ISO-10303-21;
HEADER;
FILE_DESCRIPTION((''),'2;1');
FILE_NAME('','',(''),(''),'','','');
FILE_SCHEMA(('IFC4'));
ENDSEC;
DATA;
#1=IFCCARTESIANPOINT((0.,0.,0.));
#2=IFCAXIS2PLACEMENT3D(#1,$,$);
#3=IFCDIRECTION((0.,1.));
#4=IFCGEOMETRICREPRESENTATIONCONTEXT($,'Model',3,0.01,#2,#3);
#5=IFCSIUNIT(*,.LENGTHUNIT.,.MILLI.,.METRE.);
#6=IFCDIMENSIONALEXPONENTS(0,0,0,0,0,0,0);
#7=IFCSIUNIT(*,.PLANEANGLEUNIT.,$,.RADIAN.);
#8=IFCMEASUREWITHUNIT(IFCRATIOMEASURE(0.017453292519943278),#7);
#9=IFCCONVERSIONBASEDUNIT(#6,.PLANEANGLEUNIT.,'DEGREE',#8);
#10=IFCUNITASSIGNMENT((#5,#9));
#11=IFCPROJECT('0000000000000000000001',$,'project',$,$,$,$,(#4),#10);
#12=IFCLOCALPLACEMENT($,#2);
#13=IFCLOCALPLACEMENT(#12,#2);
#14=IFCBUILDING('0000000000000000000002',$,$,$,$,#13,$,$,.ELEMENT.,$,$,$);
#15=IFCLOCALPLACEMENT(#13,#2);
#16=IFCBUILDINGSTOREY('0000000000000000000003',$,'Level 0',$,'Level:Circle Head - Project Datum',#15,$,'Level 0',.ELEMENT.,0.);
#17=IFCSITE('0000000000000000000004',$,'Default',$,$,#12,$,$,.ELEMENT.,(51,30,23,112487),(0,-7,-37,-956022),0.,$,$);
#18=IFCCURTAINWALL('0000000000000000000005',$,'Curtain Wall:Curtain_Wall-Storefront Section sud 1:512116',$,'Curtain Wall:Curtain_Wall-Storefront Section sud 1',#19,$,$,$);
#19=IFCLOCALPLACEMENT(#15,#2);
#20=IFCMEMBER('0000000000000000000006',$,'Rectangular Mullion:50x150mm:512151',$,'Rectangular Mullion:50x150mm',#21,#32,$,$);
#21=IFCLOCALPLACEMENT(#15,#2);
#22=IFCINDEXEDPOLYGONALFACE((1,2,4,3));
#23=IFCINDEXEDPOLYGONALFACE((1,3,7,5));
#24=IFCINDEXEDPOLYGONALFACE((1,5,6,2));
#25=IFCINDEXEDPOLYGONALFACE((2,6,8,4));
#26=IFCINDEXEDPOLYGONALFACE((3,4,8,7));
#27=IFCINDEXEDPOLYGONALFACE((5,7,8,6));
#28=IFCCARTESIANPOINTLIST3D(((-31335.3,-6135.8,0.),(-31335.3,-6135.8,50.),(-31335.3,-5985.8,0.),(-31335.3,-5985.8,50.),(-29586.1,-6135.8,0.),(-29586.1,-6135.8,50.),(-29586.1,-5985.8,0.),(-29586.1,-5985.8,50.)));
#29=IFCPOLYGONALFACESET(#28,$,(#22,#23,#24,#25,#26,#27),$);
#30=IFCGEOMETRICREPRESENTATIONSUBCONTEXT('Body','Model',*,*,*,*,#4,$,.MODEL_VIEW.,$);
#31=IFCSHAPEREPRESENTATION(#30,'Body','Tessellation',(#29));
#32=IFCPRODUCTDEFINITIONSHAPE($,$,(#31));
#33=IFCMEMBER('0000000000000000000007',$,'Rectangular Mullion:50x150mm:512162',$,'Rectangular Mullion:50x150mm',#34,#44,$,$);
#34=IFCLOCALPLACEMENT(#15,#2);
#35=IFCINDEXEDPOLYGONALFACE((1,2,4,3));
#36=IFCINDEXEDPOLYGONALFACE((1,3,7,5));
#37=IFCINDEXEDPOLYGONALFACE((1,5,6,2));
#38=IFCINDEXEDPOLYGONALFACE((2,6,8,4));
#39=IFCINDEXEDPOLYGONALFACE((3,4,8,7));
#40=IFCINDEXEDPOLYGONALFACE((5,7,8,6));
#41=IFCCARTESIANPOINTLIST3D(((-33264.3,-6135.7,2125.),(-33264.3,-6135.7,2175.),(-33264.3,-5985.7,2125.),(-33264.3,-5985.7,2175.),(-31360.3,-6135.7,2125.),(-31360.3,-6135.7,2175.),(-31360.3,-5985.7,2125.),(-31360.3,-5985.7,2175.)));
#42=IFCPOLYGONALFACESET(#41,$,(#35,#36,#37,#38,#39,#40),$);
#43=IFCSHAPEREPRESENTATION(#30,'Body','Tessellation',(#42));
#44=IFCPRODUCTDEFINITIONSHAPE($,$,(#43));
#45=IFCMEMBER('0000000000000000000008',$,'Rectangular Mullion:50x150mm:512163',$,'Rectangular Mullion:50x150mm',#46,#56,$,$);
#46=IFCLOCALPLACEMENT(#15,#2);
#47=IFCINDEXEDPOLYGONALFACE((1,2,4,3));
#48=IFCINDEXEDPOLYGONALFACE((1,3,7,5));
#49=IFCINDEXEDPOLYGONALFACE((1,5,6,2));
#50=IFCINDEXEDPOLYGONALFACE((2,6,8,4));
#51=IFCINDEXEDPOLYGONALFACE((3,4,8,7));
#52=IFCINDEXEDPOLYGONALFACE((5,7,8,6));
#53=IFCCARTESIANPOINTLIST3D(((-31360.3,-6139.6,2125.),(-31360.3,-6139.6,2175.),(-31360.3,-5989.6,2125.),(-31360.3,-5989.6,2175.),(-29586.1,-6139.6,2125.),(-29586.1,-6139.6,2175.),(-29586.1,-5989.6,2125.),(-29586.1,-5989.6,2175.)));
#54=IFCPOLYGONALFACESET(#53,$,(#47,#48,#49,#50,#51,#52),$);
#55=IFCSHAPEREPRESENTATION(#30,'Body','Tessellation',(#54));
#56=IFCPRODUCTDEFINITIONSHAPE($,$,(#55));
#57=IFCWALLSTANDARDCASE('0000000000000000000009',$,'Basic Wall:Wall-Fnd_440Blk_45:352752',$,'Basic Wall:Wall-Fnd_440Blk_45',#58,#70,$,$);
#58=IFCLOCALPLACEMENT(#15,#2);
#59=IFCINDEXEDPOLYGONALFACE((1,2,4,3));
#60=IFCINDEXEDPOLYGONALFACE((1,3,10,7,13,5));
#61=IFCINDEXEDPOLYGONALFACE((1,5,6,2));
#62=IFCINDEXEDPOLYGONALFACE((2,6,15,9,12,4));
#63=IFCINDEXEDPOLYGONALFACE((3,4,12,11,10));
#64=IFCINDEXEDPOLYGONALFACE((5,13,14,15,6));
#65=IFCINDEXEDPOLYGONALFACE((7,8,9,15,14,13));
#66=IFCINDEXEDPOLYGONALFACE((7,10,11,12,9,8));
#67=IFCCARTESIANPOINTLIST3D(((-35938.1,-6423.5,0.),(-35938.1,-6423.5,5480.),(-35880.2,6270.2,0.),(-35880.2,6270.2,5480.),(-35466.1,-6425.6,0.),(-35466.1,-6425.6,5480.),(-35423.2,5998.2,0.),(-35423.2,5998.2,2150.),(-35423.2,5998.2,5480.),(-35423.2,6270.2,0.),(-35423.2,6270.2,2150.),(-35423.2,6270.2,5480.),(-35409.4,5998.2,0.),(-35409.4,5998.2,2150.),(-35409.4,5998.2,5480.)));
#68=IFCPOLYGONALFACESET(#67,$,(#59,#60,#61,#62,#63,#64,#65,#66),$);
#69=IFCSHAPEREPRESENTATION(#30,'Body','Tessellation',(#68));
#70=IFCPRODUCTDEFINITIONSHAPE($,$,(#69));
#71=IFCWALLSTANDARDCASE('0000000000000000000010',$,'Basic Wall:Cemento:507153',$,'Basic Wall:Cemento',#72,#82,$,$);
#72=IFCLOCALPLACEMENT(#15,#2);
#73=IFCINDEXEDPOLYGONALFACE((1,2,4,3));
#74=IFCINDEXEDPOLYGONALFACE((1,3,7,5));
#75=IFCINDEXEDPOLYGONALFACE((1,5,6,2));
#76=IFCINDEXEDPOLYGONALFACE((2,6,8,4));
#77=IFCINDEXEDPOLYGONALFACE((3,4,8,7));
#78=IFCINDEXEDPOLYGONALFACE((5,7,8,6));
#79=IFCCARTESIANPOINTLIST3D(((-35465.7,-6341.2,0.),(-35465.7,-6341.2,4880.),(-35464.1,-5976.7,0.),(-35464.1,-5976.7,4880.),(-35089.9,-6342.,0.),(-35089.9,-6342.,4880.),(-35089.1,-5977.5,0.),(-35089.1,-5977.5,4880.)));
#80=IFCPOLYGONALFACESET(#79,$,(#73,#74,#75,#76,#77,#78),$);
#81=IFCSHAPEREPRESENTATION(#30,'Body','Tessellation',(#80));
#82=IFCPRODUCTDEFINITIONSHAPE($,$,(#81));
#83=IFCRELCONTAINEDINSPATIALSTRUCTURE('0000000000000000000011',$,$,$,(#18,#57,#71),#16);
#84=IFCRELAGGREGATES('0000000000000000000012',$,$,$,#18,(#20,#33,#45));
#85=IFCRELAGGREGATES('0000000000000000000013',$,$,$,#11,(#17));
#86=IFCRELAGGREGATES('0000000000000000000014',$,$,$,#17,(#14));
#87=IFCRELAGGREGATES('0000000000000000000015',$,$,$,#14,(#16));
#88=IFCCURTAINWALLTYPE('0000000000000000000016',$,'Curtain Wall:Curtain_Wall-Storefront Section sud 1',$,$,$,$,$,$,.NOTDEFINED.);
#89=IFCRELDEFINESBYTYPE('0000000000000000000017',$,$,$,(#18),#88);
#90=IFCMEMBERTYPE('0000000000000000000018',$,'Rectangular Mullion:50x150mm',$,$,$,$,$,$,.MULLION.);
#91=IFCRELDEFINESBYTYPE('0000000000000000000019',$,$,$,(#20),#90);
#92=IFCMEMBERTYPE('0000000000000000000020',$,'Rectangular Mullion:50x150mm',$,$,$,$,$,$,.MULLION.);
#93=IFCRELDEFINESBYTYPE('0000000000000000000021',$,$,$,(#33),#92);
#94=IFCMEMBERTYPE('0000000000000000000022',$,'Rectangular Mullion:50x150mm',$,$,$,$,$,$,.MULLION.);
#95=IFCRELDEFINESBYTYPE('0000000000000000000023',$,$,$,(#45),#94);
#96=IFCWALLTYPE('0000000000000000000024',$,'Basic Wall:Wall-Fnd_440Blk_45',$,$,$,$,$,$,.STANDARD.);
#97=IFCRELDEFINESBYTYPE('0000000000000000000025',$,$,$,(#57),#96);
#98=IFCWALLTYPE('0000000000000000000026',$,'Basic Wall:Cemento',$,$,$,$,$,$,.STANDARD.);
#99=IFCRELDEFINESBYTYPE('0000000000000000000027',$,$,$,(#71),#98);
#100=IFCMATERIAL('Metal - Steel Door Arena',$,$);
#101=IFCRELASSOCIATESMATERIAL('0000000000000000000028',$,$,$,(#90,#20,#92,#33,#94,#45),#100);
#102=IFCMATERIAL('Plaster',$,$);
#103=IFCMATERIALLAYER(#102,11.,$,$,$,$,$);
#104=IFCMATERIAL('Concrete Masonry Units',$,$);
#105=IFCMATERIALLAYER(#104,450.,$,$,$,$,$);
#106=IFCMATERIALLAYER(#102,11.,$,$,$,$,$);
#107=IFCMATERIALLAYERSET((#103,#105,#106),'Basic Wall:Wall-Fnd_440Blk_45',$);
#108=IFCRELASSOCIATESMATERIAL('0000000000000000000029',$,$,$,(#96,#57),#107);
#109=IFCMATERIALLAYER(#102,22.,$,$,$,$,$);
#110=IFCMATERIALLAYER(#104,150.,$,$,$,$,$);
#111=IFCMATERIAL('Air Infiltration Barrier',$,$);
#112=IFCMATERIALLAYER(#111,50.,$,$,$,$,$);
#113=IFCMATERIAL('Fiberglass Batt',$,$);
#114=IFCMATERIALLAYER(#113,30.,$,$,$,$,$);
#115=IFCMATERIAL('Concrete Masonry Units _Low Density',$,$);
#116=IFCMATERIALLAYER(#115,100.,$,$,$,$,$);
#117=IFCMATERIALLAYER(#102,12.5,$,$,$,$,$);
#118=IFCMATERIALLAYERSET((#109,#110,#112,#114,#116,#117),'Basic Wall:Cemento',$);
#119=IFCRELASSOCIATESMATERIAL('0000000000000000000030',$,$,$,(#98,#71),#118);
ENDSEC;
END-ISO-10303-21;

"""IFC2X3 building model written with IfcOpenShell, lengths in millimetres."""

from ifc_helpers import new_model, entity, si_unit, converted_unit, direction, frame, frame_2d, origin, origin_2d_with_axis, place, context, subcontext, project, spatial, polyline, rectangle, outline, extrude, source, transform, mapped, material, layer, layer_set, layer_usage, type_object, type_shapes, element, aggregate, save


model = new_model("IFC2X3")

# Units and contexts
model_context = context("Model", 3, precision=0.01, world=origin(), true_north=direction((0.0, 1.0)))
body_context = subcontext(model_context, "Body", "Model", "MODEL_VIEW")
ifc_project = project(units=[si_unit("LENGTHUNIT", "METRE", prefix="MILLI"), converted_unit("PLANEANGLEUNIT", "DEGREE", entity("IfcRatioMeasure", 0.017453292519943278), si_unit("PLANEANGLEUNIT", "RADIAN"), dimensions=[0, 0, 0, 0, 0, 0, 0])], contexts=[model_context])

# Site, building, storey
site_placement = place(None, origin())
site = spatial("IfcSite", under=ifc_project, at=site_placement, Name="Default", CompositionType="ELEMENT", RefLatitude=(51, 30, 23, 112487), RefLongitude=(0, -7, -37, -956022), RefElevation=0.0)
building_placement = place(site_placement, origin())
building = spatial("IfcBuilding", under=site, at=building_placement, CompositionType="ELEMENT")
storey_placement = place(building_placement, origin())
storey = spatial("IfcBuildingStorey", under=building, at=storey_placement, Name="Level 0", ObjectType="Level:Circle Head - Project Datum", LongName="Level 0", CompositionType="ELEMENT", Elevation=0.0)

# Curtain wall, members
curtain_wall_type = type_object("IfcCurtainWallType", Name="Curtain Wall:Curtain_Wall-Storefront Section sud 1", PredefinedType="NOTDEFINED")
curtain_wall_placement = place(storey_placement, origin())
curtain_wall = element("IfcCurtainWall", 1, at=curtain_wall_placement, inside=storey, type_object=curtain_wall_type, Name="Curtain Wall:Curtain_Wall-Storefront Section sud 1:512116", ObjectType="Curtain Wall:Curtain_Wall-Storefront Section sud 1")
ifc_material_1 = material(Name="Metal - Steel Door Arena")
member_type_1 = type_object("IfcMemberType", Name="Rectangular Mullion:50x150mm", PredefinedType="MULLION", material=ifc_material_1)
shared_shape_1 = source(origin(), body_context, "Body", "SweptSolid", [
    extrude(rectangle(XDim=150.0, YDim=50.0, at=origin_2d_with_axis()), frame((-25.0, 0.0, -1749.2), z_axis=(0.0, 0.0, 1.0), x_axis=(0.0, -1.0, 0.0)), (0.0, 0.0, 1.0), 1749.2),
])
type_shapes(member_type_1, [shared_shape_1])
member_1_placement = place(curtain_wall_placement, frame((-31335.3, -6060.8, 0.0), z_axis=(-1.0, 0.0, 0.0), x_axis=(0.0, 0.0, -1.0)))
member_1 = element("IfcMember", 2, at=member_1_placement, type_object=member_type_1, material=ifc_material_1, Name="Rectangular Mullion:50x150mm:512151", ObjectType="Rectangular Mullion:50x150mm", context=body_context, shape_type="MappedRepresentation", body=[
    mapped(shared_shape_1, transform((0.0, 0.0, 0.0), scale=1.0)),
])
member_type_2 = type_object("IfcMemberType", Name="Rectangular Mullion:50x150mm", PredefinedType="MULLION", material=ifc_material_1)
shared_shape_2 = source(origin(), body_context, "Body", "SweptSolid", [
    extrude(rectangle(XDim=150.0, YDim=50.0, at=origin_2d_with_axis()), frame((0.0, 0.0, -1904.0), z_axis=(0.0, 0.0, 1.0), x_axis=(0.0, -1.0, 0.0)), (0.0, 0.0, 1.0), 1904.0),
])
type_shapes(member_type_2, [shared_shape_2])
member_2_placement = place(curtain_wall_placement, frame((-31360.3, -6060.7, 2150.0), z_axis=(1.0, 0.0, 0.0), x_axis=(0.0, 0.0, 1.0)))
member_2 = element("IfcMember", 3, at=member_2_placement, type_object=member_type_2, material=ifc_material_1, Name="Rectangular Mullion:50x150mm:512162", ObjectType="Rectangular Mullion:50x150mm", context=body_context, shape_type="MappedRepresentation", body=[
    mapped(shared_shape_2, transform((0.0, 0.0, 0.0), scale=1.0)),
])
member_type_3 = type_object("IfcMemberType", Name="Rectangular Mullion:50x150mm", PredefinedType="MULLION", material=ifc_material_1)
shared_shape_3 = source(origin(), body_context, "Body", "SweptSolid", [
    extrude(rectangle(XDim=150.0, YDim=50.0, at=origin_2d_with_axis()), frame((0.0, 0.0, -1774.2), z_axis=(0.0, 0.0, 1.0), x_axis=(0.0, -1.0, 0.0)), (0.0, 0.0, 1.0), 1774.2),
])
type_shapes(member_type_3, [shared_shape_3])
member_3_placement = place(curtain_wall_placement, frame((-29586.1, -6064.6, 2150.0), z_axis=(1.0, 0.0, 0.0), x_axis=(0.0, 0.0, 1.0)))
member_3 = element("IfcMember", 4, at=member_3_placement, type_object=member_type_3, material=ifc_material_1, Name="Rectangular Mullion:50x150mm:512163", ObjectType="Rectangular Mullion:50x150mm", context=body_context, shape_type="MappedRepresentation", body=[
    mapped(shared_shape_3, transform((0.0, 0.0, 0.0), scale=1.0)),
])
aggregate(curtain_wall, [member_1, member_2, member_3])

# Wall, opening
ifc_material_2 = material(Name="Plaster")
ifc_layer_1 = layer(ifc_material_2, 11.0)
ifc_material_3 = material(Name="Concrete Masonry Units")
ifc_layer_2 = layer(ifc_material_3, 450.0)
ifc_layer_3 = layer(ifc_material_2, 11.0)
ifc_layer_set_1 = layer_set([ifc_layer_1, ifc_layer_2, ifc_layer_3], Name="Basic Wall:Wall-Fnd_440Blk_45")
ifc_layer_usage_1 = layer_usage(ifc_layer_set_1, "AXIS2", "NEGATIVE", 236.0)
wall_type_1 = type_object("IfcWallType", Name="Basic Wall:Wall-Fnd_440Blk_45", PredefinedType="STANDARD", material=ifc_layer_set_1)
wall_1_placement = place(storey_placement, frame((-35644.2, 6271.3, 0.0), z_axis=(0.0, 0.0, 1.0), x_axis=(-0.004561, -0.99999, 0.0)))
wall_1 = element("IfcWallStandardCase", 5, at=wall_1_placement, inside=storey, type_object=wall_type_1, material=ifc_layer_usage_1, Name="Basic Wall:Wall-Fnd_440Blk_45:352752", ObjectType="Basic Wall:Wall-Fnd_440Blk_45", context=body_context, shape_type="SweptSolid", body=[
    extrude(outline(polyline([(12696.0, -236.0), (12696.0, 236.0), (12611.6, 236.0), (12247.1, 236.0), (272.0, 236.0), (272.1, 222.2), (0.1, 221.0), (2.2, -236.0), (12696.0, -236.0)])), origin(), (0.0, 0.0, 1.0), 5480.0),
])
opening_placement = place(wall_1_placement, origin())
element("IfcOpeningElement", 6, at=opening_placement, cuts=wall_1, ObjectType="Opening", context=body_context, shape_type="SweptSolid", body=[
    extrude(rectangle(XDim=2150.0, YDim=272.0, at=frame_2d((0.0, 0.0), x_axis=(0.0, 1.0))), frame((136.1, 221.6, 1075.0), z_axis=(-0.004561, 0.99999, 0.0), x_axis=(-0.99999, -0.004561, 0.0)), (0.0, 0.0, 1.0), 1600.0),
])

# Wall
ifc_layer_4 = layer(ifc_material_2, 22.0)
ifc_layer_5 = layer(ifc_material_3, 150.0)
ifc_material_4 = material(Name="Air Infiltration Barrier")
ifc_layer_6 = layer(ifc_material_4, 50.0)
ifc_material_5 = material(Name="Fiberglass Batt")
ifc_layer_7 = layer(ifc_material_5, 30.0)
ifc_material_6 = material(Name="Concrete Masonry Units _Low Density")
ifc_layer_8 = layer(ifc_material_6, 100.0)
ifc_layer_9 = layer(ifc_material_2, 12.5)
ifc_layer_set_2 = layer_set([ifc_layer_4, ifc_layer_5, ifc_layer_6, ifc_layer_7, ifc_layer_8, ifc_layer_9], Name="Basic Wall:Cemento")
ifc_layer_usage_2 = layer_usage(ifc_layer_set_2, "AXIS2", "NEGATIVE", 182.3)
wall_type_2 = type_object("IfcWallType", Name="Basic Wall:Cemento", PredefinedType="STANDARD", material=ifc_layer_set_2)
wall_2_placement = place(storey_placement, frame((-35089.5, -6159.8, 0.0), z_axis=(0.0, 0.0, 1.0), x_axis=(-0.999998, 0.002199, 0.0)))
element("IfcWallStandardCase", 7, at=wall_2_placement, inside=storey, type_object=wall_type_2, material=ifc_layer_usage_2, Name="Basic Wall:Cemento:507153", ObjectType="Basic Wall:Cemento", context=body_context, shape_type="SweptSolid", body=[
    extrude(outline(polyline([(374.9, -182.2), (375.8, 182.3), (0.0, 182.3), (0.0, -182.2), (374.9, -182.2)])), origin(), (0.0, 0.0, 1.0), 4880.0),
])

save(model, "model.ifc")
